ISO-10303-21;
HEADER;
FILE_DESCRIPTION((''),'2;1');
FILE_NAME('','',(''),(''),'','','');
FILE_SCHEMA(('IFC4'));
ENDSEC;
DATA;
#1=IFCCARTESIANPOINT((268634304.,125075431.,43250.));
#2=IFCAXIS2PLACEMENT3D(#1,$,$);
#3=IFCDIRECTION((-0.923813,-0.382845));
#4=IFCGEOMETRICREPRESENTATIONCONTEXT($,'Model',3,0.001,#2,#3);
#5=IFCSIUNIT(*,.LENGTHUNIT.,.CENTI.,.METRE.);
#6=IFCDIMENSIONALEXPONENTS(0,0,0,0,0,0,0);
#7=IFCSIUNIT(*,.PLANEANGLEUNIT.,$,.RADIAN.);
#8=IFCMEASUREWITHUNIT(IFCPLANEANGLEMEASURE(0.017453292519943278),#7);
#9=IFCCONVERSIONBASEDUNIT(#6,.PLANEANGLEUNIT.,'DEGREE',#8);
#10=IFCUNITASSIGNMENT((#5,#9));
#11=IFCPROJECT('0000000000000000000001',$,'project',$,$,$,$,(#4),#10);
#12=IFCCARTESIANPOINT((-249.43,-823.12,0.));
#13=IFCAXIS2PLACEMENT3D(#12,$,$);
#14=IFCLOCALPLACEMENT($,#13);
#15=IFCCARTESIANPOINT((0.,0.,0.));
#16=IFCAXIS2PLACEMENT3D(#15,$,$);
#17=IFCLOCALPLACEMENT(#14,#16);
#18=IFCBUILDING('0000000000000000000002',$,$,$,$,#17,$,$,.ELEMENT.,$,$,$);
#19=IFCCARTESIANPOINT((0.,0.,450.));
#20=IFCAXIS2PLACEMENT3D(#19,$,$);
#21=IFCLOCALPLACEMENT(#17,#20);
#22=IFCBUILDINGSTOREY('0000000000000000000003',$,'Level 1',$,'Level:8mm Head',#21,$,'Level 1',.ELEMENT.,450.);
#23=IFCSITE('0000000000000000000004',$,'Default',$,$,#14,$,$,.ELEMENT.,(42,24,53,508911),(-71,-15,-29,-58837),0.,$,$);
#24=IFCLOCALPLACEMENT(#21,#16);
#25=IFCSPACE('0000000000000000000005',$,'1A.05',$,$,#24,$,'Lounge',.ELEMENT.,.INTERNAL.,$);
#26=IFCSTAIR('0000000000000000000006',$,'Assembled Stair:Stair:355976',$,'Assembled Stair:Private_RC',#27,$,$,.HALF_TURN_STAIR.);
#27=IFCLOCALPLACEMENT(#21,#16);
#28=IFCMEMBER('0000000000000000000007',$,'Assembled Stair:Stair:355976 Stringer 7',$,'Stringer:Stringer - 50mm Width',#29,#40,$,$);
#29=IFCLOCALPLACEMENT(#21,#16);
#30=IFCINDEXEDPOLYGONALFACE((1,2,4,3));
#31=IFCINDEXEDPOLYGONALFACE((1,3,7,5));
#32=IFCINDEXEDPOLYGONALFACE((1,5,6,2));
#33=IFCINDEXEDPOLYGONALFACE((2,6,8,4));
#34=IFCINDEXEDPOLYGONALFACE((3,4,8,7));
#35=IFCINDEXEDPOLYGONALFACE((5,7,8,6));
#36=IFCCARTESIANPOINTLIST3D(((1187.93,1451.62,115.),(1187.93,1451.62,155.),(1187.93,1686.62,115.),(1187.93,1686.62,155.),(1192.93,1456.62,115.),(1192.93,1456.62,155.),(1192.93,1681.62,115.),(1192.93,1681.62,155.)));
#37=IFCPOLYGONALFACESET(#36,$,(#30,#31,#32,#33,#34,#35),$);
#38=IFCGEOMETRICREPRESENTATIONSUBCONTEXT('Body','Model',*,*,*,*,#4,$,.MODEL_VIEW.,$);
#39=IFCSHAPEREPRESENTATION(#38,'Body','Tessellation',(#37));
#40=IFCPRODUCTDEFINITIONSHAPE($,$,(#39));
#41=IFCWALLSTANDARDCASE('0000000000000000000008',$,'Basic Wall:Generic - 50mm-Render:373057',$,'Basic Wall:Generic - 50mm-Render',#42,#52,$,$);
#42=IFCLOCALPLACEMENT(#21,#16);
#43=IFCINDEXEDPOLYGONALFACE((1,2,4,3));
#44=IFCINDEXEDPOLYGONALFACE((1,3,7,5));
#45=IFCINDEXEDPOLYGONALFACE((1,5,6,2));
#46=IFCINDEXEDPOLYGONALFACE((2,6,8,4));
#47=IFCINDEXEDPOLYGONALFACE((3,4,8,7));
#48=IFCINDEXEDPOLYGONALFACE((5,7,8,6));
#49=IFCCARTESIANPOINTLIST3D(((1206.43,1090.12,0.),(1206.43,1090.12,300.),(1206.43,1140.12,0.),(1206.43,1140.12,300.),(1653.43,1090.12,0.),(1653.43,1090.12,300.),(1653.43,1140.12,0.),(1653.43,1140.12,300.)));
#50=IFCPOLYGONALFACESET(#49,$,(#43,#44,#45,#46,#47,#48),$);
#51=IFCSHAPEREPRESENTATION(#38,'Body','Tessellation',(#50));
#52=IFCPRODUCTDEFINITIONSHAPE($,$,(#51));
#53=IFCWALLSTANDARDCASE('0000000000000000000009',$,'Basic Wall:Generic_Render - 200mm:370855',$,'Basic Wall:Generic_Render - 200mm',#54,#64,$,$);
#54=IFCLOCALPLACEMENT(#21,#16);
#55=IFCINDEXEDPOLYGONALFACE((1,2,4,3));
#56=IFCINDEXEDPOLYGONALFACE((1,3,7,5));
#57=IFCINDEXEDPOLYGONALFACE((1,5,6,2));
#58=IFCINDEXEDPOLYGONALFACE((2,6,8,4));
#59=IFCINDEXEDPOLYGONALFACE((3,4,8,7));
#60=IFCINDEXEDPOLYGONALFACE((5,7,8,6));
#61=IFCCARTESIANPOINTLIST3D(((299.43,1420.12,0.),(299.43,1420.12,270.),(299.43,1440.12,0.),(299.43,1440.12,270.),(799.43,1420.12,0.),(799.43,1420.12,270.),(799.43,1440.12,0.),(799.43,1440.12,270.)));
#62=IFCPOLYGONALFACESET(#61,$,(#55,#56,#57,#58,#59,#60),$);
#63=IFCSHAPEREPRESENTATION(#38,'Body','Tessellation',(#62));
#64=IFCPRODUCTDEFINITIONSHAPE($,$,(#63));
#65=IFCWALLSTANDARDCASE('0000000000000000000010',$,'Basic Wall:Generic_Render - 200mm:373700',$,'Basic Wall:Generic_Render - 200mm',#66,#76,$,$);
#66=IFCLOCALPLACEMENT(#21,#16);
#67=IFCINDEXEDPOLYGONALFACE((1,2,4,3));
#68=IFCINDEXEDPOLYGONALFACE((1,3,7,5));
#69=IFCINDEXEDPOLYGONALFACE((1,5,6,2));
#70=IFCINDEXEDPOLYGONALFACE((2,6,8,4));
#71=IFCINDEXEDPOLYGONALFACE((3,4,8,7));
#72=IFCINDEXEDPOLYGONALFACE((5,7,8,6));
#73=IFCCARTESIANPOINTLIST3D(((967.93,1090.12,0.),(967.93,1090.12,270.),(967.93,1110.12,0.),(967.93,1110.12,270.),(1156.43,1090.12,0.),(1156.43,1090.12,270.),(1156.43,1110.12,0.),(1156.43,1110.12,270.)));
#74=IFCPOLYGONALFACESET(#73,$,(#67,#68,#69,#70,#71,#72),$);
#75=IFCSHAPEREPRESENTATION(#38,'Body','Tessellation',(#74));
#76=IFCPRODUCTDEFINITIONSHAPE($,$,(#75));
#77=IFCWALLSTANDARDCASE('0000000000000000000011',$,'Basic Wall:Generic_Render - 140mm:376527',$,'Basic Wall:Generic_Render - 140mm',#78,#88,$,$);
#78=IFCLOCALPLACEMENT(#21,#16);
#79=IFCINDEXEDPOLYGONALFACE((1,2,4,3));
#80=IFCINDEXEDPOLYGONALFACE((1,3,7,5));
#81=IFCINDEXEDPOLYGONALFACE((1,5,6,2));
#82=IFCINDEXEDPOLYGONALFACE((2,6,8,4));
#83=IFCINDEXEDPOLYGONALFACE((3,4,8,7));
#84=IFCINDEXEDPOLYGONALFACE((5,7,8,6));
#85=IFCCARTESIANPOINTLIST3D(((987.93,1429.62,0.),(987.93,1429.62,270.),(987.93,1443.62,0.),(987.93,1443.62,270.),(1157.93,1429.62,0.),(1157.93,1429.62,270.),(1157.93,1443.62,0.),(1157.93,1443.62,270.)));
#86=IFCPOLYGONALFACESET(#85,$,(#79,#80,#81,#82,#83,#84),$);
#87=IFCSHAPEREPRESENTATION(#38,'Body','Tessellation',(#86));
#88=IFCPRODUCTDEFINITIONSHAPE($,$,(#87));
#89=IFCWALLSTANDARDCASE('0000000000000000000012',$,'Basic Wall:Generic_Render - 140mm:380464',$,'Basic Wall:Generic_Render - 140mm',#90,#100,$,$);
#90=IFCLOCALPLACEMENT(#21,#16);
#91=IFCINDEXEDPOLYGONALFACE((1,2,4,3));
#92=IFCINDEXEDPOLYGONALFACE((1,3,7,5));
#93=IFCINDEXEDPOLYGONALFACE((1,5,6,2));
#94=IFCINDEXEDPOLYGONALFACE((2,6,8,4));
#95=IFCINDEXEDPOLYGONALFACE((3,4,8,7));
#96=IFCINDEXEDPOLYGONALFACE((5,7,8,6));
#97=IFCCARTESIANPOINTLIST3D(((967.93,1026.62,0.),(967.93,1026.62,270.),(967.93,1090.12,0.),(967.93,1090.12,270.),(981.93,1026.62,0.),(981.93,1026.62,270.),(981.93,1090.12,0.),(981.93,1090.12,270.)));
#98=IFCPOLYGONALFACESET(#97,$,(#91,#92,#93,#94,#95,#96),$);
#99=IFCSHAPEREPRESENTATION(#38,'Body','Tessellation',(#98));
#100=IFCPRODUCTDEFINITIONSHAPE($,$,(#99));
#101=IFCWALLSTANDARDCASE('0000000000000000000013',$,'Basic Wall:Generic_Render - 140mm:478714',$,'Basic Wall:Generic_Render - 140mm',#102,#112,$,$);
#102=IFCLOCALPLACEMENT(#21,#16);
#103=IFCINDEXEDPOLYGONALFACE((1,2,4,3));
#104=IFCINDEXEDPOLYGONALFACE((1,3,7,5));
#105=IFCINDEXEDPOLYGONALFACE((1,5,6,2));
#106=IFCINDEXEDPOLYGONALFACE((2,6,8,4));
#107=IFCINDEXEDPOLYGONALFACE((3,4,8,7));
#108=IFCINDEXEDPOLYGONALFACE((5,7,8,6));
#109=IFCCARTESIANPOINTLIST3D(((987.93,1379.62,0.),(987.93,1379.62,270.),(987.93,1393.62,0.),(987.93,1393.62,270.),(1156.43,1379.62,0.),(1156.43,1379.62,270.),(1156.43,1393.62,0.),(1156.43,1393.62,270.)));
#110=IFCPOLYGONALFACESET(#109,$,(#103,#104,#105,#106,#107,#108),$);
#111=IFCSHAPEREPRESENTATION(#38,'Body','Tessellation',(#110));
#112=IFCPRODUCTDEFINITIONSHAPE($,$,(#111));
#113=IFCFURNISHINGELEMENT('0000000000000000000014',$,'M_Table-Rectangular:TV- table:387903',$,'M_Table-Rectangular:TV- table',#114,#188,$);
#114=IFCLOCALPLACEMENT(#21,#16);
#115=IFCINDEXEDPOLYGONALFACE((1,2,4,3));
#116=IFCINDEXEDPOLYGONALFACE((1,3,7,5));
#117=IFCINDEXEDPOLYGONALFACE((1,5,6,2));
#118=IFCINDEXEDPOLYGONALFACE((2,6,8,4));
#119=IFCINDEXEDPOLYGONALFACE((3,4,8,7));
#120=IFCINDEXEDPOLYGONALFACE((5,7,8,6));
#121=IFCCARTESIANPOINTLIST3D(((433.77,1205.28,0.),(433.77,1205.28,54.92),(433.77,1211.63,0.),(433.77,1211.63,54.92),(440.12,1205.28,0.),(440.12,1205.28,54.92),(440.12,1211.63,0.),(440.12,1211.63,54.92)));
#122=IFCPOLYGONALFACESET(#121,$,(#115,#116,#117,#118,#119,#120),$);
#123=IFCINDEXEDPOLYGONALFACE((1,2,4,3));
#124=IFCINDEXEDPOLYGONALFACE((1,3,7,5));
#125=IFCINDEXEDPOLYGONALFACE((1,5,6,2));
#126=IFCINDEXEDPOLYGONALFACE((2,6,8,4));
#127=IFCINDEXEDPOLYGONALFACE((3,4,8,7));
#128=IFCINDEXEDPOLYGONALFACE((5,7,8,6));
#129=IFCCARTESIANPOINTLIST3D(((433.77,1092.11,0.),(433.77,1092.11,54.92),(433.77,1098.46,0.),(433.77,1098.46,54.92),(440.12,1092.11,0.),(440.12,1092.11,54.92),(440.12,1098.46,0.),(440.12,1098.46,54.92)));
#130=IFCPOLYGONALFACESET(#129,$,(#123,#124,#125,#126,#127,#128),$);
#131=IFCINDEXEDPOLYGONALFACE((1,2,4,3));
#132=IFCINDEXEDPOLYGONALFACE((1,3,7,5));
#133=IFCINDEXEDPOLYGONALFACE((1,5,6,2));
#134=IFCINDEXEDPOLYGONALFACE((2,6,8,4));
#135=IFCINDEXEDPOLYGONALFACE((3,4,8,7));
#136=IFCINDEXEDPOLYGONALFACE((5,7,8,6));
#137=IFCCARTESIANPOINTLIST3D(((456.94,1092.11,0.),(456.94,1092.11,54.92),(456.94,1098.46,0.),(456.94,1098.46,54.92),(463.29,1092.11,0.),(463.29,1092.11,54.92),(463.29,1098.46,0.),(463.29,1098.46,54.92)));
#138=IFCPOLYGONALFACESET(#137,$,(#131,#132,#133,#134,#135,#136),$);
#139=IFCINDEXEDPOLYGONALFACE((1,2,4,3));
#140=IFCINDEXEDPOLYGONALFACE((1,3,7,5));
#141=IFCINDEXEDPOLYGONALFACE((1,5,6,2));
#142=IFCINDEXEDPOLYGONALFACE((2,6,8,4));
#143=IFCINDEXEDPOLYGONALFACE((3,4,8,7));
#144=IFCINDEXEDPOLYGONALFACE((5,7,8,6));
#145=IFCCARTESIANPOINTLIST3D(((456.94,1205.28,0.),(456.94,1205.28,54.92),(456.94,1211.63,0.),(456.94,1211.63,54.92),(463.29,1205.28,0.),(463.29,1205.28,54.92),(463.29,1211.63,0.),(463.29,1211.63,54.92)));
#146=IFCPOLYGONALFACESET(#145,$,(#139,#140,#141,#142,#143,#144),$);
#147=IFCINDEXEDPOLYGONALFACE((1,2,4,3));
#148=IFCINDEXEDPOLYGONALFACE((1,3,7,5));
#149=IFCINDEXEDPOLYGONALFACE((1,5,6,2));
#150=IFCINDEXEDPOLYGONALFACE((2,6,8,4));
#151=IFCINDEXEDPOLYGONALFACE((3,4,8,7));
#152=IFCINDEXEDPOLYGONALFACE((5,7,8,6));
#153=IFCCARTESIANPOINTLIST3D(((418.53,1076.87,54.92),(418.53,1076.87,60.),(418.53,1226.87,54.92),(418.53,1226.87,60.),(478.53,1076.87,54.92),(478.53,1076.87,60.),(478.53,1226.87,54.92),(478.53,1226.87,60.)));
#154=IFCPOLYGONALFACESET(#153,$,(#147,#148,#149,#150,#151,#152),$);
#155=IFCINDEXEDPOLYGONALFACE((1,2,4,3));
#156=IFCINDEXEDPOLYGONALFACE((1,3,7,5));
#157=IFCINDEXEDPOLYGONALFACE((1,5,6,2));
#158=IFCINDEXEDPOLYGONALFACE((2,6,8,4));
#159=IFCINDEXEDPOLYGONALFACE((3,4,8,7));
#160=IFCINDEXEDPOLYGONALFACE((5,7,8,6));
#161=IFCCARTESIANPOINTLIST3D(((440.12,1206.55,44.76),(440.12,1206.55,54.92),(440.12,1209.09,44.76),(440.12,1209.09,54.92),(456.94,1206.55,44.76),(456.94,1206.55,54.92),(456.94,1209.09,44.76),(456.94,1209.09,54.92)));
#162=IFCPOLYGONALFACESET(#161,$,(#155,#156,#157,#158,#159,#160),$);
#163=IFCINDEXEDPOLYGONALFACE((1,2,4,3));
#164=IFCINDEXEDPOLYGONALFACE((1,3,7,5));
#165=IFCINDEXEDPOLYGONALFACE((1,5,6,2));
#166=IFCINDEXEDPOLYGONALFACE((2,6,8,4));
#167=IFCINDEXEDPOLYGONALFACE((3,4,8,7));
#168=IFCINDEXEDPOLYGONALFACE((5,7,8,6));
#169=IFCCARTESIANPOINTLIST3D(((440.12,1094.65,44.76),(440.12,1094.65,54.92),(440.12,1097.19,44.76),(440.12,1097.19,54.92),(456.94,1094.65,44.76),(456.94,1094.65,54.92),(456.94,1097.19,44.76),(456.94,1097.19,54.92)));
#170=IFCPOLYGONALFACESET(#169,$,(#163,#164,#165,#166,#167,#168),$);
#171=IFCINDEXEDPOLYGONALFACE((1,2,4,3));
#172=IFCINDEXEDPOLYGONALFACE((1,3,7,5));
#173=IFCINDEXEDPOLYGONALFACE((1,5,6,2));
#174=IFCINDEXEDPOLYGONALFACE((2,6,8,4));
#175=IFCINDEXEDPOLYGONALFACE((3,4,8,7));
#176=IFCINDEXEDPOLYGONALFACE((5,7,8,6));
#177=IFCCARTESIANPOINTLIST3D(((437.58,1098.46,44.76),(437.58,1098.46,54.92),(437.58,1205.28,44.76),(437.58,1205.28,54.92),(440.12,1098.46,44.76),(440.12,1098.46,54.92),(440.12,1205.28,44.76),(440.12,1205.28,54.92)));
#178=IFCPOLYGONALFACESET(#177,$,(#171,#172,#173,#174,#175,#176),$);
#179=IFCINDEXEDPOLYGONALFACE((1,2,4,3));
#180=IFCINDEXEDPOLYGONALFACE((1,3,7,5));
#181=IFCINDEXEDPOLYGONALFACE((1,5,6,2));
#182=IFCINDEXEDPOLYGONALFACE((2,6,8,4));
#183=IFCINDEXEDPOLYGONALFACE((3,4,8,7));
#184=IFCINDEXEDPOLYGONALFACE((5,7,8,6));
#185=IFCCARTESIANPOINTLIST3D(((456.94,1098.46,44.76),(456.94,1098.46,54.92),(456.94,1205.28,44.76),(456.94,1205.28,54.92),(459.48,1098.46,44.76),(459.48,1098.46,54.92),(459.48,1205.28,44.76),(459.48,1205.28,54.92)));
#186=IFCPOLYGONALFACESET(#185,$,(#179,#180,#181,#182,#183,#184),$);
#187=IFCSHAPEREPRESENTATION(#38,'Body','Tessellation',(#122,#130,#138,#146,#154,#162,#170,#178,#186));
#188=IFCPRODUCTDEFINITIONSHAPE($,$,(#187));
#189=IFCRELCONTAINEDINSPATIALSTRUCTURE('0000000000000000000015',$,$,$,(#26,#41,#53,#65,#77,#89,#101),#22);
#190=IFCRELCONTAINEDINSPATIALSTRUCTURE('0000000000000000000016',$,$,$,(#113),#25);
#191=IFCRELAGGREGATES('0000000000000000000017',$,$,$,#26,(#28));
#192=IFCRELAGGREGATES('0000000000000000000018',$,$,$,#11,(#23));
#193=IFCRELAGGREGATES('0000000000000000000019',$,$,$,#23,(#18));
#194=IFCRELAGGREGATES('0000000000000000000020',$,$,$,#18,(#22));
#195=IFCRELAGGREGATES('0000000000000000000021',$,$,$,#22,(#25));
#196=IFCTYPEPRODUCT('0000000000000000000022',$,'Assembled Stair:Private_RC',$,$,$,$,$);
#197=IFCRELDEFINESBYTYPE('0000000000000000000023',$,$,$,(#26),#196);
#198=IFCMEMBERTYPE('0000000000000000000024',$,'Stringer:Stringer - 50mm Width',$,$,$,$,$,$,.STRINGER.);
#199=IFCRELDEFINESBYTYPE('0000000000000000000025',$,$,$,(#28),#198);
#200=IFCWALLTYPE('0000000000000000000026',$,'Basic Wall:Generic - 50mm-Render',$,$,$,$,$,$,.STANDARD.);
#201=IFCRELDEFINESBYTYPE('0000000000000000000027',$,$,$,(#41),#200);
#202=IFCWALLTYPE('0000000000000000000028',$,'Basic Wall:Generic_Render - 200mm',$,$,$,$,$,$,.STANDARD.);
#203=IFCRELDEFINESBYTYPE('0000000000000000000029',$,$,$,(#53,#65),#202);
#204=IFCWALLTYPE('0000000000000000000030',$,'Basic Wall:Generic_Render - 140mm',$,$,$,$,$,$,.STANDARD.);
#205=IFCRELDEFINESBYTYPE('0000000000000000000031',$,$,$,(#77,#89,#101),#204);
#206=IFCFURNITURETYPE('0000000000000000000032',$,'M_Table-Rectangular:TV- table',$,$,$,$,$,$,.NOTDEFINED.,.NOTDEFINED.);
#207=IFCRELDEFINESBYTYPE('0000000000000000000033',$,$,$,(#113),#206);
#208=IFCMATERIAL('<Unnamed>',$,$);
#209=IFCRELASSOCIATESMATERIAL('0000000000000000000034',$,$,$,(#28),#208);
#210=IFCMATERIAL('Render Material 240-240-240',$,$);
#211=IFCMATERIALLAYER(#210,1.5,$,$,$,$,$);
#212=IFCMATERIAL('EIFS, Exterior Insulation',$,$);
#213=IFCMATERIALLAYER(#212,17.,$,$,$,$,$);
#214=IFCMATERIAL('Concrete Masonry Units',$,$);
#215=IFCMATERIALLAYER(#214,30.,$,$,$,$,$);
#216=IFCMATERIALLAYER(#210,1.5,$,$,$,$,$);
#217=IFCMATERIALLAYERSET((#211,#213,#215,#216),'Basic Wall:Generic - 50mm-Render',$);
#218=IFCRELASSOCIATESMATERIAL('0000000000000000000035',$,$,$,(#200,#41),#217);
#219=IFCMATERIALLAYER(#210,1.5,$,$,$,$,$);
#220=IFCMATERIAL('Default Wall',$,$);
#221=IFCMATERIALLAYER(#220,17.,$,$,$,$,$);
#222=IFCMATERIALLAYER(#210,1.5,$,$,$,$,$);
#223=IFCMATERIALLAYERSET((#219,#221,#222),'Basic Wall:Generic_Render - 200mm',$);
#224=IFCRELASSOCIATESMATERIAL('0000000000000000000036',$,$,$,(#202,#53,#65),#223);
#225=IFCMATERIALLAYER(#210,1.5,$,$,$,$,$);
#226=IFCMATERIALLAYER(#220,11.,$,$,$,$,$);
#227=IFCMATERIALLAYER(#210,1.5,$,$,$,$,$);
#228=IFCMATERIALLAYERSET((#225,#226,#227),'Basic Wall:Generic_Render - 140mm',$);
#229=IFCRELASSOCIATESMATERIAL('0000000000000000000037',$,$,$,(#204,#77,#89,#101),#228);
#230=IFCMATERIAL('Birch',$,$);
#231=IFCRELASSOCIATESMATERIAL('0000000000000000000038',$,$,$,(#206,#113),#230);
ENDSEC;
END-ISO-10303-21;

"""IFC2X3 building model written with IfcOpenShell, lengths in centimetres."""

from ifc_helpers import new_model, entity, si_unit, converted_unit, direction, frame, frame_2d, origin, origin_2d_with_axis, place, context, subcontext, project, spatial, polyline, rectangle, outline, extrude, source, transform, mapped, material, layer, layer_set, layer_usage, type_object, type_shapes, element, aggregate, save


model = new_model("IFC2X3")

# Units and contexts
model_context = context("Model", 3, precision=0.001, world=frame((268634304.0, 125075431.0, 43250.0)), true_north=direction((-0.923813, -0.382845)))
body_context = subcontext(model_context, "Body", "Model", "MODEL_VIEW")
ifc_project = project(units=[si_unit("LENGTHUNIT", "METRE", prefix="CENTI"), converted_unit("PLANEANGLEUNIT", "DEGREE", entity("IfcPlaneAngleMeasure", 0.017453292519943278), si_unit("PLANEANGLEUNIT", "RADIAN"), dimensions=[0, 0, 0, 0, 0, 0, 0])], contexts=[model_context])

# Site, building, storey
site_placement = place(None, frame((-249.43, -823.12, 0.0)))
site = spatial("IfcSite", under=ifc_project, at=site_placement, Name="Default", CompositionType="ELEMENT", RefLatitude=(42, 24, 53, 508911), RefLongitude=(-71, -15, -29, -58837), RefElevation=0.0)
building_placement = place(site_placement, origin())
building = spatial("IfcBuilding", under=site, at=building_placement, CompositionType="ELEMENT")
storey_placement = place(building_placement, frame((0.0, 0.0, 450.0)))
storey = spatial("IfcBuildingStorey", under=building, at=storey_placement, Name="Level 1", ObjectType="Level:8mm Head", LongName="Level 1", CompositionType="ELEMENT", Elevation=450.0)

# Stair, member
type_product = type_object("IfcTypeProduct", Name="Assembled Stair:Private_RC")
stair_placement = place(storey_placement, origin())
stair = element("IfcStair", 1, at=stair_placement, inside=storey, type_object=type_product, Name="Assembled Stair:Stair:355976", ObjectType="Assembled Stair:Private_RC", ShapeType="HALF_TURN_STAIR")
ifc_material_1 = material(Name="<Unnamed>")
member_type = type_object("IfcMemberType", Name="Stringer:Stringer - 50mm Width", PredefinedType="STRINGER")
member_1_placement = place(stair_placement, frame((1187.93, 1451.62, 115.0)))
member_1 = element("IfcMember", 2, at=member_1_placement, type_object=member_type, material=ifc_material_1, Name="Assembled Stair:Stair:355976 Stringer 7", ObjectType="Stringer:Stringer - 50mm Width", context=body_context, shape_type="SweptSolid", body=[
    extrude(outline(polyline([(-117.5, -2.5), (117.5, -2.5), (112.5, 2.5), (-112.5, 2.5), (-117.5, -2.5)])), frame((2.5, 117.5, 0.0), z_axis=(0.0, 0.0, 1.0), x_axis=(0.0, -1.0, 0.0)), (0.0, 0.0, 1.0), 40.0),
])
aggregate(stair, [member_1])

# Walls
ifc_material_2 = material(Name="Render Material 240-240-240")
ifc_layer_1 = layer(ifc_material_2, 1.5)
ifc_material_3 = material(Name="EIFS, Exterior Insulation")
ifc_layer_2 = layer(ifc_material_3, 17.0)
ifc_material_4 = material(Name="Concrete Masonry Units")
ifc_layer_3 = layer(ifc_material_4, 30.0)
ifc_layer_4 = layer(ifc_material_2, 1.5)
ifc_layer_set_1 = layer_set([ifc_layer_1, ifc_layer_2, ifc_layer_3, ifc_layer_4], Name="Basic Wall:Generic - 50mm-Render")
ifc_layer_usage_1 = layer_usage(ifc_layer_set_1, "AXIS2", "NEGATIVE", 25.0)
wall_type_1 = type_object("IfcWallType", Name="Basic Wall:Generic - 50mm-Render", PredefinedType="STANDARD", material=ifc_layer_set_1)
wall_1_placement = place(storey_placement, frame((1206.43, 1115.12, 0.0)))
element("IfcWallStandardCase", 3, at=wall_1_placement, inside=storey, type_object=wall_type_1, material=ifc_layer_usage_1, Name="Basic Wall:Generic - 50mm-Render:373057", ObjectType="Basic Wall:Generic - 50mm-Render", context=body_context, shape_type="SweptSolid", body=[
    extrude(rectangle(XDim=447.0, YDim=50.0, at=frame_2d((223.5, 0.0), x_axis=(-1.0, 0.0))), origin(), (0.0, 0.0, 1.0), 300.0),
])
ifc_layer_5 = layer(ifc_material_2, 1.5)
ifc_material_5 = material(Name="Default Wall")
ifc_layer_6 = layer(ifc_material_5, 17.0)
ifc_layer_7 = layer(ifc_material_2, 1.5)
ifc_layer_set_2 = layer_set([ifc_layer_5, ifc_layer_6, ifc_layer_7], Name="Basic Wall:Generic_Render - 200mm")
ifc_layer_usage_2 = layer_usage(ifc_layer_set_2, "AXIS2", "NEGATIVE", 10.0)
wall_type_2 = type_object("IfcWallType", Name="Basic Wall:Generic_Render - 200mm", PredefinedType="STANDARD", material=ifc_layer_set_2)
wall_2_placement = place(storey_placement, frame((799.43, 1430.12, 0.0), z_axis=(0.0, 0.0, 1.0), x_axis=(-1.0, 0.0, 0.0)))
element("IfcWallStandardCase", 4, at=wall_2_placement, inside=storey, type_object=wall_type_2, material=ifc_layer_usage_2, Name="Basic Wall:Generic_Render - 200mm:370855", ObjectType="Basic Wall:Generic_Render - 200mm", context=body_context, shape_type="SweptSolid", body=[
    extrude(rectangle(XDim=500.0, YDim=20.0, at=frame_2d((250.0, 0.0), x_axis=(-1.0, 0.0))), origin(), (0.0, 0.0, 1.0), 270.0),
])
ifc_layer_usage_3 = layer_usage(ifc_layer_set_2, "AXIS2", "NEGATIVE", 10.0)
wall_3_placement = place(storey_placement, frame((1156.43, 1100.12, 0.0), z_axis=(0.0, 0.0, 1.0), x_axis=(-1.0, 0.0, 0.0)))
element("IfcWallStandardCase", 5, at=wall_3_placement, inside=storey, type_object=wall_type_2, material=ifc_layer_usage_3, Name="Basic Wall:Generic_Render - 200mm:373700", ObjectType="Basic Wall:Generic_Render - 200mm", context=body_context, shape_type="SweptSolid", body=[
    extrude(rectangle(XDim=188.5, YDim=20.0, at=frame_2d((94.25, 0.0), x_axis=(-1.0, 0.0))), origin(), (0.0, 0.0, 1.0), 270.0),
])
ifc_layer_8 = layer(ifc_material_2, 1.5)
ifc_layer_9 = layer(ifc_material_5, 11.0)
ifc_layer_10 = layer(ifc_material_2, 1.5)
ifc_layer_set_3 = layer_set([ifc_layer_8, ifc_layer_9, ifc_layer_10], Name="Basic Wall:Generic_Render - 140mm")
ifc_layer_usage_4 = layer_usage(ifc_layer_set_3, "AXIS2", "NEGATIVE", 7.0)
wall_type_3 = type_object("IfcWallType", Name="Basic Wall:Generic_Render - 140mm", PredefinedType="STANDARD", material=ifc_layer_set_3)
wall_4_placement = place(storey_placement, frame((1157.93, 1436.62, 0.0), z_axis=(0.0, 0.0, 1.0), x_axis=(-1.0, 0.0, 0.0)))
element("IfcWallStandardCase", 6, at=wall_4_placement, inside=storey, type_object=wall_type_3, material=ifc_layer_usage_4, Name="Basic Wall:Generic_Render - 140mm:376527", ObjectType="Basic Wall:Generic_Render - 140mm", context=body_context, shape_type="SweptSolid", body=[
    extrude(rectangle(XDim=170.0, YDim=14.0, at=frame_2d((85.0, 0.0), x_axis=(-1.0, 0.0))), origin(), (0.0, 0.0, 1.0), 270.0),
])
ifc_layer_usage_5 = layer_usage(ifc_layer_set_3, "AXIS2", "NEGATIVE", 7.0)
wall_5_placement = place(storey_placement, frame((974.93, 1090.12, 0.0), z_axis=(0.0, 0.0, 1.0), x_axis=(0.0, -1.0, 0.0)))
element("IfcWallStandardCase", 7, at=wall_5_placement, inside=storey, type_object=wall_type_3, material=ifc_layer_usage_5, Name="Basic Wall:Generic_Render - 140mm:380464", ObjectType="Basic Wall:Generic_Render - 140mm", context=body_context, shape_type="SweptSolid", body=[
    extrude(rectangle(XDim=63.5, YDim=14.0, at=frame_2d((31.75, 0.0), x_axis=(-1.0, 0.0))), origin(), (0.0, 0.0, 1.0), 270.0),
])
ifc_layer_usage_6 = layer_usage(ifc_layer_set_3, "AXIS2", "NEGATIVE", 7.0)
wall_6_placement = place(storey_placement, frame((1156.43, 1386.62, 0.0), z_axis=(0.0, 0.0, 1.0), x_axis=(-1.0, 0.0, 0.0)))
element("IfcWallStandardCase", 8, at=wall_6_placement, inside=storey, type_object=wall_type_3, material=ifc_layer_usage_6, Name="Basic Wall:Generic_Render - 140mm:478714", ObjectType="Basic Wall:Generic_Render - 140mm", context=body_context, shape_type="SweptSolid", body=[
    extrude(rectangle(XDim=168.5, YDim=14.0, at=frame_2d((84.25, 0.0), x_axis=(-1.0, 0.0))), origin(), (0.0, 0.0, 1.0), 270.0),
])

# Shared definitions
space_1_placement = place(storey_placement, origin())
space_1 = spatial("IfcSpace", under=storey, at=space_1_placement, Name="1A.05", LongName="Lounge", CompositionType="ELEMENT", InteriorOrExteriorSpace="INTERNAL")

# Furnishing element
ifc_material_6 = material(Name="Birch")
furniture_type_1 = type_object("IfcFurnitureType", Name="M_Table-Rectangular:TV- table", AssemblyPlace="NOTDEFINED", material=ifc_material_6)
shared_shape_1 = source(origin(), body_context, "Body", "SweptSolid", [
    extrude(rectangle(XDim=6.35, YDim=6.35, at=origin_2d_with_axis()), frame((56.58, 11.59, 0.0), z_axis=(0.0, 0.0, 1.0), x_axis=(0.0, -1.0, 0.0)), (0.0, 0.0, 1.0), 54.92),
    extrude(rectangle(XDim=6.35, YDim=6.35, at=frame_2d((0.0, 0.0), x_axis=(1.0, 0.0))), frame((-56.58, 11.59, 0.0), z_axis=(0.0, 0.0, 1.0), x_axis=(-1.0, 0.0, 0.0)), (0.0, 0.0, 1.0), 54.92),
    extrude(rectangle(XDim=6.35, YDim=6.35, at=origin_2d_with_axis()), frame((-56.58, -11.59, 0.0), z_axis=(0.0, 0.0, 1.0), x_axis=(0.0, 1.0, 0.0)), (0.0, 0.0, 1.0), 54.92),
    extrude(rectangle(XDim=6.35, YDim=6.35, at=origin_2d_with_axis()), frame((56.58, -11.59, 0.0)), (0.0, 0.0, 1.0), 54.92),
    extrude(rectangle(XDim=150.0, YDim=60.0, at=origin_2d_with_axis()), frame((0.0, 0.0, 54.92), z_axis=(0.0, 0.0, 1.0), x_axis=(-1.0, 0.0, 0.0)), (0.0, 0.0, 1.0), 5.08),
    extrude(rectangle(XDim=2.54, YDim=16.82, at=origin_2d_with_axis()), frame((55.95, 0.0, 44.76)), (0.0, 0.0, 1.0), 10.16),
    extrude(rectangle(XDim=16.82, YDim=2.54, at=origin_2d_with_axis()), frame((-55.95, 0.0, 44.76), z_axis=(0.0, 0.0, 1.0), x_axis=(0.0, 1.0, 0.0)), (0.0, 0.0, 1.0), 10.16),
    extrude(rectangle(XDim=106.82, YDim=2.54, at=frame_2d((0.0, 0.0), x_axis=(1.0, 0.0))), frame((0.0, 9.68, 44.76), z_axis=(0.0, 0.0, 1.0), x_axis=(-1.0, 0.0, 0.0)), (0.0, 0.0, 1.0), 10.16),
    extrude(rectangle(XDim=2.54, YDim=106.82, at=origin_2d_with_axis()), frame((0.0, -9.68, 44.76), z_axis=(0.0, 0.0, 1.0), x_axis=(0.0, 1.0, 0.0)), (0.0, 0.0, 1.0), 10.16),
])
type_shapes(furniture_type_1, [shared_shape_1])
furnishing_1_placement = place(space_1_placement, frame((448.53, 1151.87, 0.0), z_axis=(0.0, 0.0, 1.0), x_axis=(0.0, 1.0, 0.0)))
element("IfcFurnishingElement", 9, at=furnishing_1_placement, inside=space_1, type_object=furniture_type_1, material=ifc_material_6, Name="M_Table-Rectangular:TV- table:387903", ObjectType="M_Table-Rectangular:TV- table", context=body_context, shape_type="MappedRepresentation", body=[
    mapped(shared_shape_1, transform((0.0, 0.0, 0.0), scale=1.0)),
])

save(model, "model.ifc")
